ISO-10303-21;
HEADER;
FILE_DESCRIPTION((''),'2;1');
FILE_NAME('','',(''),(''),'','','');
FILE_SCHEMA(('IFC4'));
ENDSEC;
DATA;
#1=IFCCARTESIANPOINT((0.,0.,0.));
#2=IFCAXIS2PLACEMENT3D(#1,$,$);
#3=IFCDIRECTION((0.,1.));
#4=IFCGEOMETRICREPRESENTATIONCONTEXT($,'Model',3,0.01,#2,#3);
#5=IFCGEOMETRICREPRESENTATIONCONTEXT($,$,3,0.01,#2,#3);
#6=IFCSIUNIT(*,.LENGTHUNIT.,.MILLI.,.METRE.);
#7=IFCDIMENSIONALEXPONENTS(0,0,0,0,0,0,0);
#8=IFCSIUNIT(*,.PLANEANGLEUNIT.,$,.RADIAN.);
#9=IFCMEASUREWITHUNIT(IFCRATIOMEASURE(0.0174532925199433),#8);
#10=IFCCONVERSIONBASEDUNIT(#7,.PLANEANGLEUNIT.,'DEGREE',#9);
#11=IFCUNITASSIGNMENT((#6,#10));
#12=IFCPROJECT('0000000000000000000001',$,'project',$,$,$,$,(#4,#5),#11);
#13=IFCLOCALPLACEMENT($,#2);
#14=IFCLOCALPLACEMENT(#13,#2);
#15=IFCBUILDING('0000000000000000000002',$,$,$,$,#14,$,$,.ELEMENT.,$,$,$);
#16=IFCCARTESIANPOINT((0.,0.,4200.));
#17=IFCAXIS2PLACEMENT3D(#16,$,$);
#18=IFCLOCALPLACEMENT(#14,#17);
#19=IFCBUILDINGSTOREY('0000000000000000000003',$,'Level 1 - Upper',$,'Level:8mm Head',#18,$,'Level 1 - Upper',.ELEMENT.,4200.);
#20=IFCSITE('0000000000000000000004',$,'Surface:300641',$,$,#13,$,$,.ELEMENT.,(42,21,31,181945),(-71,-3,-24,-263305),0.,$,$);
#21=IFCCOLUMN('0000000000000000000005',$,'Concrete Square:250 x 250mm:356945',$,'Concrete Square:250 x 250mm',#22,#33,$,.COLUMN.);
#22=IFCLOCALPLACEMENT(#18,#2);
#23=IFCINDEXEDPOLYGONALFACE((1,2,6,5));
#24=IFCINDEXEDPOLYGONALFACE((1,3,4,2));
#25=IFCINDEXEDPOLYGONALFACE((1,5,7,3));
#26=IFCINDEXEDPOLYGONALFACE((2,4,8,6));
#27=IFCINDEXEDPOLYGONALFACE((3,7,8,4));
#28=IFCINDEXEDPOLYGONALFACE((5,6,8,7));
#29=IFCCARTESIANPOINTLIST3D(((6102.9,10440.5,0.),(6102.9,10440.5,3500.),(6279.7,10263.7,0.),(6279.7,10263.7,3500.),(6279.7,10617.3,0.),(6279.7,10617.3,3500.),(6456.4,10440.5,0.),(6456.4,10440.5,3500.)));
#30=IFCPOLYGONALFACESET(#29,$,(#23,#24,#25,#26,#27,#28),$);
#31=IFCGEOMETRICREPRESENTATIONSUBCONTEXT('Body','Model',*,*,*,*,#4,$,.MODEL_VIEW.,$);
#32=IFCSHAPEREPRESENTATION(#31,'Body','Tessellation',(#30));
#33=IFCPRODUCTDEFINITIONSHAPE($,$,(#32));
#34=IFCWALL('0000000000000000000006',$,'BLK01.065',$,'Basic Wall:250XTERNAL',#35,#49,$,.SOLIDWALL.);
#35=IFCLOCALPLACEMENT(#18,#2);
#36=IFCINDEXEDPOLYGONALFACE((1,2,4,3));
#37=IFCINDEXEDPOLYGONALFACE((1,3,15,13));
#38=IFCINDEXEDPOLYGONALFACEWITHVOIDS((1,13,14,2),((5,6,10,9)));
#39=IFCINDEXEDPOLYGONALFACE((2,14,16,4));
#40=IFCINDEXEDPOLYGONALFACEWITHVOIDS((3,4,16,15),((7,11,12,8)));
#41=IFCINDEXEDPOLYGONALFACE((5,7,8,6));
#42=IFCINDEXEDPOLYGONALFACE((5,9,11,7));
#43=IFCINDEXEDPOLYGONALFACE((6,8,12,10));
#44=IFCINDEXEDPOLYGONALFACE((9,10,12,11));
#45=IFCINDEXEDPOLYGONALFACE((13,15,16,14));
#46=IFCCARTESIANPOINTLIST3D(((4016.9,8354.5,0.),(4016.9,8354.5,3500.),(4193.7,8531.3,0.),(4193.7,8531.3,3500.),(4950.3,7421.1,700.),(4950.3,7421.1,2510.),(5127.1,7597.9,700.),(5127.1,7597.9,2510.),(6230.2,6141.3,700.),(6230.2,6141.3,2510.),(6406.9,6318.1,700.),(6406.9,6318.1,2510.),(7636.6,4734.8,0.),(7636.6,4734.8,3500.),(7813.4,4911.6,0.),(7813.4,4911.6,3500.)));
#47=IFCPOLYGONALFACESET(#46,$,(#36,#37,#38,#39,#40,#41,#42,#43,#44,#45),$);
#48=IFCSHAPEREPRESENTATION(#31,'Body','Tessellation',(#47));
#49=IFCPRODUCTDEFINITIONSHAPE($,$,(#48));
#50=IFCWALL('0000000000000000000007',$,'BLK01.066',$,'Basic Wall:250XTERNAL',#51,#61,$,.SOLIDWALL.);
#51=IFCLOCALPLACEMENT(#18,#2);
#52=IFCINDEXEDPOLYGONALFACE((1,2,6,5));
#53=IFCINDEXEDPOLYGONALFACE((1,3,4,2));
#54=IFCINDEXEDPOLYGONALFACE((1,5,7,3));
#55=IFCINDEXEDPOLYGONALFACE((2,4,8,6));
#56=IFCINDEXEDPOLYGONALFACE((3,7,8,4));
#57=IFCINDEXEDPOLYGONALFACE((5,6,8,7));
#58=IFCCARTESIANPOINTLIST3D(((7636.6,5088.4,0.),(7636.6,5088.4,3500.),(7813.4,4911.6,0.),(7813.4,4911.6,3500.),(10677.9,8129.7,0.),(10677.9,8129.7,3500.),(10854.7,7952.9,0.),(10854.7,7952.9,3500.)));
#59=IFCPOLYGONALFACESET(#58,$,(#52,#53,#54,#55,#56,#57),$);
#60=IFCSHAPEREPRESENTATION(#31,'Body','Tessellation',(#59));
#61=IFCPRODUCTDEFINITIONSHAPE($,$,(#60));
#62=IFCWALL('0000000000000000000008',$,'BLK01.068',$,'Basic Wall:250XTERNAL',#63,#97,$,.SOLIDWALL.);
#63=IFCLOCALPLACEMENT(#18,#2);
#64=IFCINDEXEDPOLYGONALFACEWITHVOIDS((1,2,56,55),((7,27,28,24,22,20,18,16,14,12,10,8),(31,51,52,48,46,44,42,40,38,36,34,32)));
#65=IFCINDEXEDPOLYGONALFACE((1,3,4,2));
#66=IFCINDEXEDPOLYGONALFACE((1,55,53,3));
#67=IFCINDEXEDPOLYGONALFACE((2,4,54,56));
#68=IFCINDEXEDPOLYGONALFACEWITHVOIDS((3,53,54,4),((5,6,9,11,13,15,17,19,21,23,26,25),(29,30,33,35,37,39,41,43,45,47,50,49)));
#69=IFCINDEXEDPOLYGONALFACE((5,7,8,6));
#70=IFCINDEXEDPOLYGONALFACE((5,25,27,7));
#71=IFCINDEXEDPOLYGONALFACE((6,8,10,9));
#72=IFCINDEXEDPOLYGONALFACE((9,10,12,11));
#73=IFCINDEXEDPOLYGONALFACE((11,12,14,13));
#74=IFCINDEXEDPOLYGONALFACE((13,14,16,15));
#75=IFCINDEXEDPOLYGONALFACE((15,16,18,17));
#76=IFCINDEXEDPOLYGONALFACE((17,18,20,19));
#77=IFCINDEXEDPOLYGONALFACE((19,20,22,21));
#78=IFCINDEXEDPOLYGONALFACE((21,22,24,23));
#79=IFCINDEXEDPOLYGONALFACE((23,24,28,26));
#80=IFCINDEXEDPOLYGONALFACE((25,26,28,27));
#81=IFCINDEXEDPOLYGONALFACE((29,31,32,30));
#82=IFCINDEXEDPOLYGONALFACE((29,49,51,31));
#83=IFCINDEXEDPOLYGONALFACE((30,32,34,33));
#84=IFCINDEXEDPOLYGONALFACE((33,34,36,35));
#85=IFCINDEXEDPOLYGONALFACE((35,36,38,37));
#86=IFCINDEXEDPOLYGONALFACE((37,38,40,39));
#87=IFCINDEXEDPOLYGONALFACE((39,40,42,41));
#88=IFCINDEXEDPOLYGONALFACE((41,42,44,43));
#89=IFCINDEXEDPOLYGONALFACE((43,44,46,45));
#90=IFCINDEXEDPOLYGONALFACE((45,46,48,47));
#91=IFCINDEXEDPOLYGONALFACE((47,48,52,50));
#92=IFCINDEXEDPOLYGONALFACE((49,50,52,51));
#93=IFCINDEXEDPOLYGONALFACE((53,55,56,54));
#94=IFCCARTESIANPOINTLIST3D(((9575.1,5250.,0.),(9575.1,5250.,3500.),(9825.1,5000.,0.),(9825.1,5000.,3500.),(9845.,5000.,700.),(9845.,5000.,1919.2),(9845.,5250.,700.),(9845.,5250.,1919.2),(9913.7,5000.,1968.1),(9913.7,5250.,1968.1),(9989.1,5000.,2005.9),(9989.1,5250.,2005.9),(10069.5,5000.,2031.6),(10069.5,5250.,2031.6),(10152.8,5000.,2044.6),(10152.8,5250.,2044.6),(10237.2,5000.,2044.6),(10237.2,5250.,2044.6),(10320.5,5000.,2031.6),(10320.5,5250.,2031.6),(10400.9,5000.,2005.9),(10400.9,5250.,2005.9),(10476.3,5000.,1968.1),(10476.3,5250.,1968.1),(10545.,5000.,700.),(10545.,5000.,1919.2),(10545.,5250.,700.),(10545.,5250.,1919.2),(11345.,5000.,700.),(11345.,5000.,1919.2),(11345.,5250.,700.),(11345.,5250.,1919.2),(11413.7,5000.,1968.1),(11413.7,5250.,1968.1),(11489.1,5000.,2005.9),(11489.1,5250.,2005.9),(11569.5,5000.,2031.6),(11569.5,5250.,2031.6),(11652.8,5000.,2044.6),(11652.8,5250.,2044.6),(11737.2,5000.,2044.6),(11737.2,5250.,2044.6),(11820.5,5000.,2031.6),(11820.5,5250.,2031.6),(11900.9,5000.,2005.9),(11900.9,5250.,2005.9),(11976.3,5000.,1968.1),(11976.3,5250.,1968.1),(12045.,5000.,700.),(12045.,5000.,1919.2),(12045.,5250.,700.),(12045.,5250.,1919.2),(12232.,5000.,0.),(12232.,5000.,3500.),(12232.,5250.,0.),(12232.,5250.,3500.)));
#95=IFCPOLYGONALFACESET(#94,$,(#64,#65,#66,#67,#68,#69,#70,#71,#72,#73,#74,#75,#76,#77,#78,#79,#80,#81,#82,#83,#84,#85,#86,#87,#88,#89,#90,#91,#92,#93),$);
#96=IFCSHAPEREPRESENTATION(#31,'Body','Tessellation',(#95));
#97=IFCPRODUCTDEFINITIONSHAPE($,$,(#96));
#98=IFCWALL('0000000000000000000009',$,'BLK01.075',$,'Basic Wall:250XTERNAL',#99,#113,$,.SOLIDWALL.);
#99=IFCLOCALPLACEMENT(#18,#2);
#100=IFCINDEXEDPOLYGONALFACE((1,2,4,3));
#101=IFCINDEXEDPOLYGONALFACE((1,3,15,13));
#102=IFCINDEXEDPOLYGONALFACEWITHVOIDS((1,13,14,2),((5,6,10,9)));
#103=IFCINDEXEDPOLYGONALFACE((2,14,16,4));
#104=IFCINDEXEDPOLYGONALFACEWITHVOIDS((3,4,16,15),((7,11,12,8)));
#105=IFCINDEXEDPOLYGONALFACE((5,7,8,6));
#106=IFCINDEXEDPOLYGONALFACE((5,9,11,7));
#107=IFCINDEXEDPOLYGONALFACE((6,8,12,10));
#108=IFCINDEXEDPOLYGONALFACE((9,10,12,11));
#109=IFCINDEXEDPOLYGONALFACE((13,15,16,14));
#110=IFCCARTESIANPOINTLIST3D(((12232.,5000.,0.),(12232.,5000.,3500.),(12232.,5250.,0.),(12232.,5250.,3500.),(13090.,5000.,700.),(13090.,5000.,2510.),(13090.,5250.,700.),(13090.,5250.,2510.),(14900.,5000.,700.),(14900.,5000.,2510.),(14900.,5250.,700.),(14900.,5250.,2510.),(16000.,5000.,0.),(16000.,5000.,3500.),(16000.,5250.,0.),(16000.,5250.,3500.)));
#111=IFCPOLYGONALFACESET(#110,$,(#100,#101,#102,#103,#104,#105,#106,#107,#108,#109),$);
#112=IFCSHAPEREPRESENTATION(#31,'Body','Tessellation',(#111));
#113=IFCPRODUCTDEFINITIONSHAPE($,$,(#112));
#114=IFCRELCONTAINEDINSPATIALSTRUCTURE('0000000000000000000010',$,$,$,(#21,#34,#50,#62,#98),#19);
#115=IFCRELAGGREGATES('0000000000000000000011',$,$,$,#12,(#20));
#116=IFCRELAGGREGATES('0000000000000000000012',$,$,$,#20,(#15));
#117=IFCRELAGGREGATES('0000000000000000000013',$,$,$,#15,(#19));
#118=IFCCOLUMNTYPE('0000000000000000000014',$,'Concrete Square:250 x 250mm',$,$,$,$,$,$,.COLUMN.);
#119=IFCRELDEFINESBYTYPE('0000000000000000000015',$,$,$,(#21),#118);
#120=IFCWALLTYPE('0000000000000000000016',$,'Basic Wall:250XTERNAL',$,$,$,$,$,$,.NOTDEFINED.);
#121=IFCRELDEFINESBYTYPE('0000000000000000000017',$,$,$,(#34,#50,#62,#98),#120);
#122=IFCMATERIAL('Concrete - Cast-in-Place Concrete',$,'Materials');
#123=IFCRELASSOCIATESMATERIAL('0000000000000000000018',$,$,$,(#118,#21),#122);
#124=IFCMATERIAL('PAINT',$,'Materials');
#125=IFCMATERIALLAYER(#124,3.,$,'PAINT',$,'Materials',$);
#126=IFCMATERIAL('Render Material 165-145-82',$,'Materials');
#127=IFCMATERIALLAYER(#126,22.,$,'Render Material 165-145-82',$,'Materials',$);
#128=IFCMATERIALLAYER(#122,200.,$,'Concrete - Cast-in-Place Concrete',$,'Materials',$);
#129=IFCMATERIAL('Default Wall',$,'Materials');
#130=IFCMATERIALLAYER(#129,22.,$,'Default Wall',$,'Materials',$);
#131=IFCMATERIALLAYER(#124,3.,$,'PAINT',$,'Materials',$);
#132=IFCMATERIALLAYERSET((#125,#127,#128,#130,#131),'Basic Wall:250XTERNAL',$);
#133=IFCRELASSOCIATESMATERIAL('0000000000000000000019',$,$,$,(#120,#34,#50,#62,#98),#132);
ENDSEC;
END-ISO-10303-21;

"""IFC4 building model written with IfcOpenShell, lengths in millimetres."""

from ifc_helpers import new_model, entity, si_unit, converted_unit, direction, frame, frame_2d, origin, origin_2d_with_axis, place, context, subcontext, project, spatial, polyline, circle_curve, parameter, trimmed, segment, composite_curve, rectangle, outline, extrude, clip, halfspace, source, transform, mapped, material, layer, layer_set, layer_usage, material_profile, profile_set, profile_usage, type_object, type_shapes, element, save


model = new_model("IFC4")

# Units and contexts
model_context = context("Model", 3, precision=0.01, world=origin(), true_north=direction((0.0, 1.0)))
context_of_model = context(None, 3, precision=0.01, world=origin(), true_north=direction((0.0, 1.0)))
body_context = subcontext(model_context, "Body", "Model", "MODEL_VIEW")
ifc_project = project(units=[si_unit("LENGTHUNIT", "METRE", prefix="MILLI"), converted_unit("PLANEANGLEUNIT", "DEGREE", entity("IfcRatioMeasure", 0.0174532925199433), si_unit("PLANEANGLEUNIT", "RADIAN"), dimensions=[0, 0, 0, 0, 0, 0, 0])], contexts=[model_context, context_of_model])

# Site, building, storey
site_placement = place(None, origin())
site = spatial("IfcSite", under=ifc_project, at=site_placement, Name="Surface:300641", CompositionType="ELEMENT", RefLatitude=(42, 21, 31, 181945), RefLongitude=(-71, -3, -24, -263305), RefElevation=0.0)
building_placement = place(site_placement, origin())
building = spatial("IfcBuilding", under=site, at=building_placement, CompositionType="ELEMENT")
storey_placement = place(building_placement, frame((0.0, 0.0, 4200.0)))
storey = spatial("IfcBuildingStorey", under=building, at=storey_placement, Name="Level 1 - Upper", ObjectType="Level:8mm Head", LongName="Level 1 - Upper", CompositionType="ELEMENT", Elevation=4200.0)

# Column
ifc_material_1 = material(Name="Concrete - Cast-in-Place Concrete", Category="Materials")
ifc_material_profile_1 = material_profile(ifc_material_1, rectangle(XDim=250.0, YDim=250.0, at=frame_2d((0.0, 0.0), x_axis=(1.0, 0.0))), Name="250 x 250mm")
ifc_profile_set_1 = profile_set([ifc_material_profile_1], Name="250 x 250mm")
ifc_profile_usage_1 = profile_usage(ifc_profile_set_1)
column_type = type_object("IfcColumnType", Name="Concrete Square:250 x 250mm", PredefinedType="COLUMN", material=ifc_profile_set_1)
shared_shape_1 = source(origin(), body_context, "Body", "SweptSolid", [
    extrude(rectangle(XDim=250.0, YDim=250.0, at=origin_2d_with_axis()), frame((6279.7, 10440.5, 4200.0), z_axis=(0.0, 0.0, 1.0), x_axis=(-0.707107, 0.707107, 0.0)), (0.0, 0.0, 1.0), 3500.0),
])
type_shapes(column_type, [shared_shape_1])
column_placement = place(storey_placement, frame((0.0, 0.0, -4200.0)))
element("IfcColumn", 1, at=column_placement, inside=storey, type_object=column_type, material=ifc_profile_usage_1, Name="Concrete Square:250 x 250mm:356945", ObjectType="Concrete Square:250 x 250mm", PredefinedType="COLUMN", context=body_context, shape_type="MappedRepresentation", body=[
    mapped(shared_shape_1, transform((0.0, 0.0, 0.0), scale=1.0)),
])

# Wall, opening
ifc_material_2 = material(Name="PAINT", Category="Materials")
ifc_layer_1 = layer(ifc_material_2, 3.0, Name="PAINT", Category="Materials")
ifc_material_3 = material(Name="Render Material 165-145-82", Category="Materials")
ifc_layer_2 = layer(ifc_material_3, 22.0, Name="Render Material 165-145-82", Category="Materials")
ifc_layer_3 = layer(ifc_material_1, 200.0, Name="Concrete - Cast-in-Place Concrete", Category="Materials")
ifc_material_4 = material(Name="Default Wall", Category="Materials")
ifc_layer_4 = layer(ifc_material_4, 22.0, Name="Default Wall", Category="Materials")
ifc_layer_5 = layer(ifc_material_2, 3.0, Name="PAINT", Category="Materials")
ifc_layer_set_1 = layer_set([ifc_layer_1, ifc_layer_2, ifc_layer_3, ifc_layer_4, ifc_layer_5], Name="Basic Wall:250XTERNAL")
ifc_layer_usage_1 = layer_usage(ifc_layer_set_1, "AXIS2", "NEGATIVE", 125.0)
wall_type_1 = type_object("IfcWallType", Name="Basic Wall:250XTERNAL", PredefinedType="NOTDEFINED", material=ifc_layer_set_1)
wall_1_placement = place(storey_placement, frame((7725.0, 4823.2, 0.0), z_axis=(0.0, 0.0, 1.0), x_axis=(-0.707107, 0.707107, 0.0)))
wall_1 = element("IfcWall", 2, at=wall_1_placement, inside=storey, type_object=wall_type_1, material=ifc_layer_usage_1, Name="BLK01.065", ObjectType="Basic Wall:250XTERNAL", PredefinedType="SOLIDWALL", context=body_context, shape_type="Clipping", body=[
    clip(extrude(rectangle(XDim=5119.0, YDim=250.0, at=frame_2d((2559.5, 0.0), x_axis=(-1.0, 0.0))), origin(), (0.0, 0.0, 1.0), 3500.0), halfspace(origin(), True)),
])
opening_1_placement = place(wall_1_placement, frame((1989.0, -125.0, 700.0)))
element("IfcOpeningElement", 3, at=opening_1_placement, cuts=wall_1, ObjectType="Opening", PredefinedType="OPENING", context=body_context, shape_type="SweptSolid", body=[
    extrude(rectangle(XDim=1810.0, YDim=1810.0, at=frame_2d((905.0, 905.0), x_axis=(-1.0, 0.0))), frame((0.0, 0.0, 0.0), z_axis=(0.0, 1.0, 0.0), x_axis=(0.0, 0.0, 1.0)), (0.0, 0.0, 1.0), 250.0),
])

# Wall
ifc_layer_usage_2 = layer_usage(ifc_layer_set_1, "AXIS2", "NEGATIVE", 125.0)
wall_2_placement = place(storey_placement, frame((7725.0, 5000.0, 0.0), z_axis=(0.0, 0.0, 1.0), x_axis=(0.707107, 0.707107, 0.0)))
element("IfcWall", 4, at=wall_2_placement, inside=storey, type_object=wall_type_1, material=ifc_layer_usage_2, Name="BLK01.066", ObjectType="Basic Wall:250XTERNAL", PredefinedType="SOLIDWALL", context=body_context, shape_type="Clipping", body=[
    clip(extrude(rectangle(XDim=4301.0, YDim=250.0, at=frame_2d((2150.5, 0.0), x_axis=(-1.0, 0.0))), origin(), (0.0, 0.0, 1.0), 3500.0), halfspace(origin(), True)),
])

# Wall, openings
ifc_layer_usage_3 = layer_usage(ifc_layer_set_1, "AXIS2", "NEGATIVE", 125.0)
wall_3_placement = place(storey_placement, frame((9575.1, 5125.0, 0.0)))
wall_3 = element("IfcWall", 5, at=wall_3_placement, inside=storey, type_object=wall_type_1, material=ifc_layer_usage_3, Name="BLK01.068", ObjectType="Basic Wall:250XTERNAL", PredefinedType="SOLIDWALL", context=body_context, shape_type="Clipping", body=[
    clip(extrude(outline(polyline([(2656.9, -125.0), (2656.9, 125.0), (0.0, 125.0), (250.0, -125.0), (2656.9, -125.0)])), origin(), (0.0, 0.0, 1.0), 3500.0), halfspace(origin(), True)),
])
opening_2_placement = place(wall_3_placement, frame((969.9, 125.0, 700.0)))
element("IfcOpeningElement", 6, at=opening_2_placement, cuts=wall_3, ObjectType="Opening", PredefinedType="OPENING", context=body_context, shape_type="SweptSolid", body=[
    extrude(outline(composite_curve([segment(polyline([(0.0, 0.0), (1219.2, 0.0)]), True, "CONTINUOUS"), segment(trimmed(circle_curve(frame_2d((800.4, 350.0), x_axis=(0.0, 1.0)), 545.8), [parameter(230.112671)], [parameter(309.887329)], True, "PARAMETER"), True, "CONTINUOUS"), segment(polyline([(1219.2, 700.0), (0.0, 700.0)]), True, "CONTINUOUS"), segment(polyline([(0.0, 700.0), (0.0, 0.0)]), True, "CONTINUOUS")], self_intersect=False)), frame((0.0, 0.0, 0.0), z_axis=(0.0, -1.0, 0.0), x_axis=(0.0, 0.0, 1.0)), (0.0, 0.0, 1.0), 250.0),
])
opening_3_placement = place(wall_3_placement, frame((2469.9, 125.0, 700.0)))
element("IfcOpeningElement", 7, at=opening_3_placement, cuts=wall_3, ObjectType="Opening", PredefinedType="OPENING", context=body_context, shape_type="SweptSolid", body=[
    extrude(outline(composite_curve([segment(polyline([(0.0, 0.0), (1219.2, 0.0)]), True, "CONTINUOUS"), segment(trimmed(circle_curve(frame_2d((800.4, 350.0), x_axis=(0.0, 1.0)), 545.8), [parameter(230.112671)], [parameter(309.887329)], True, "PARAMETER"), True, "CONTINUOUS"), segment(polyline([(1219.2, 700.0), (0.0, 700.0)]), True, "CONTINUOUS"), segment(polyline([(0.0, 700.0), (0.0, 0.0)]), True, "CONTINUOUS")], self_intersect=False)), frame((0.0, 0.0, 0.0), z_axis=(0.0, -1.0, 0.0), x_axis=(0.0, 0.0, 1.0)), (0.0, 0.0, 1.0), 250.0),
])

# Wall, opening
ifc_layer_usage_4 = layer_usage(ifc_layer_set_1, "AXIS2", "NEGATIVE", 125.0)
wall_4_placement = place(storey_placement, frame((12232.0, 5125.0, 0.0)))
wall_4 = element("IfcWall", 8, at=wall_4_placement, inside=storey, type_object=wall_type_1, material=ifc_layer_usage_4, Name="BLK01.075", ObjectType="Basic Wall:250XTERNAL", PredefinedType="SOLIDWALL", context=body_context, shape_type="Clipping", body=[
    clip(extrude(rectangle(XDim=3768.0, YDim=250.0, at=frame_2d((1884.0, 0.0), x_axis=(-1.0, 0.0))), origin(), (0.0, 0.0, 1.0), 3500.0), halfspace(origin(), True)),
])
opening_4_placement = place(wall_4_placement, frame((2668.0, 125.0, 700.0)))
element("IfcOpeningElement", 9, at=opening_4_placement, cuts=wall_4, ObjectType="Opening", PredefinedType="OPENING", context=body_context, shape_type="SweptSolid", body=[
    extrude(rectangle(XDim=1810.0, YDim=1810.0, at=frame_2d((905.0, 905.0), x_axis=(-1.0, 0.0))), frame((0.0, 0.0, 0.0), z_axis=(0.0, -1.0, 0.0), x_axis=(0.0, 0.0, 1.0)), (0.0, 0.0, 1.0), 250.0),
])

save(model, "model.ifc")
